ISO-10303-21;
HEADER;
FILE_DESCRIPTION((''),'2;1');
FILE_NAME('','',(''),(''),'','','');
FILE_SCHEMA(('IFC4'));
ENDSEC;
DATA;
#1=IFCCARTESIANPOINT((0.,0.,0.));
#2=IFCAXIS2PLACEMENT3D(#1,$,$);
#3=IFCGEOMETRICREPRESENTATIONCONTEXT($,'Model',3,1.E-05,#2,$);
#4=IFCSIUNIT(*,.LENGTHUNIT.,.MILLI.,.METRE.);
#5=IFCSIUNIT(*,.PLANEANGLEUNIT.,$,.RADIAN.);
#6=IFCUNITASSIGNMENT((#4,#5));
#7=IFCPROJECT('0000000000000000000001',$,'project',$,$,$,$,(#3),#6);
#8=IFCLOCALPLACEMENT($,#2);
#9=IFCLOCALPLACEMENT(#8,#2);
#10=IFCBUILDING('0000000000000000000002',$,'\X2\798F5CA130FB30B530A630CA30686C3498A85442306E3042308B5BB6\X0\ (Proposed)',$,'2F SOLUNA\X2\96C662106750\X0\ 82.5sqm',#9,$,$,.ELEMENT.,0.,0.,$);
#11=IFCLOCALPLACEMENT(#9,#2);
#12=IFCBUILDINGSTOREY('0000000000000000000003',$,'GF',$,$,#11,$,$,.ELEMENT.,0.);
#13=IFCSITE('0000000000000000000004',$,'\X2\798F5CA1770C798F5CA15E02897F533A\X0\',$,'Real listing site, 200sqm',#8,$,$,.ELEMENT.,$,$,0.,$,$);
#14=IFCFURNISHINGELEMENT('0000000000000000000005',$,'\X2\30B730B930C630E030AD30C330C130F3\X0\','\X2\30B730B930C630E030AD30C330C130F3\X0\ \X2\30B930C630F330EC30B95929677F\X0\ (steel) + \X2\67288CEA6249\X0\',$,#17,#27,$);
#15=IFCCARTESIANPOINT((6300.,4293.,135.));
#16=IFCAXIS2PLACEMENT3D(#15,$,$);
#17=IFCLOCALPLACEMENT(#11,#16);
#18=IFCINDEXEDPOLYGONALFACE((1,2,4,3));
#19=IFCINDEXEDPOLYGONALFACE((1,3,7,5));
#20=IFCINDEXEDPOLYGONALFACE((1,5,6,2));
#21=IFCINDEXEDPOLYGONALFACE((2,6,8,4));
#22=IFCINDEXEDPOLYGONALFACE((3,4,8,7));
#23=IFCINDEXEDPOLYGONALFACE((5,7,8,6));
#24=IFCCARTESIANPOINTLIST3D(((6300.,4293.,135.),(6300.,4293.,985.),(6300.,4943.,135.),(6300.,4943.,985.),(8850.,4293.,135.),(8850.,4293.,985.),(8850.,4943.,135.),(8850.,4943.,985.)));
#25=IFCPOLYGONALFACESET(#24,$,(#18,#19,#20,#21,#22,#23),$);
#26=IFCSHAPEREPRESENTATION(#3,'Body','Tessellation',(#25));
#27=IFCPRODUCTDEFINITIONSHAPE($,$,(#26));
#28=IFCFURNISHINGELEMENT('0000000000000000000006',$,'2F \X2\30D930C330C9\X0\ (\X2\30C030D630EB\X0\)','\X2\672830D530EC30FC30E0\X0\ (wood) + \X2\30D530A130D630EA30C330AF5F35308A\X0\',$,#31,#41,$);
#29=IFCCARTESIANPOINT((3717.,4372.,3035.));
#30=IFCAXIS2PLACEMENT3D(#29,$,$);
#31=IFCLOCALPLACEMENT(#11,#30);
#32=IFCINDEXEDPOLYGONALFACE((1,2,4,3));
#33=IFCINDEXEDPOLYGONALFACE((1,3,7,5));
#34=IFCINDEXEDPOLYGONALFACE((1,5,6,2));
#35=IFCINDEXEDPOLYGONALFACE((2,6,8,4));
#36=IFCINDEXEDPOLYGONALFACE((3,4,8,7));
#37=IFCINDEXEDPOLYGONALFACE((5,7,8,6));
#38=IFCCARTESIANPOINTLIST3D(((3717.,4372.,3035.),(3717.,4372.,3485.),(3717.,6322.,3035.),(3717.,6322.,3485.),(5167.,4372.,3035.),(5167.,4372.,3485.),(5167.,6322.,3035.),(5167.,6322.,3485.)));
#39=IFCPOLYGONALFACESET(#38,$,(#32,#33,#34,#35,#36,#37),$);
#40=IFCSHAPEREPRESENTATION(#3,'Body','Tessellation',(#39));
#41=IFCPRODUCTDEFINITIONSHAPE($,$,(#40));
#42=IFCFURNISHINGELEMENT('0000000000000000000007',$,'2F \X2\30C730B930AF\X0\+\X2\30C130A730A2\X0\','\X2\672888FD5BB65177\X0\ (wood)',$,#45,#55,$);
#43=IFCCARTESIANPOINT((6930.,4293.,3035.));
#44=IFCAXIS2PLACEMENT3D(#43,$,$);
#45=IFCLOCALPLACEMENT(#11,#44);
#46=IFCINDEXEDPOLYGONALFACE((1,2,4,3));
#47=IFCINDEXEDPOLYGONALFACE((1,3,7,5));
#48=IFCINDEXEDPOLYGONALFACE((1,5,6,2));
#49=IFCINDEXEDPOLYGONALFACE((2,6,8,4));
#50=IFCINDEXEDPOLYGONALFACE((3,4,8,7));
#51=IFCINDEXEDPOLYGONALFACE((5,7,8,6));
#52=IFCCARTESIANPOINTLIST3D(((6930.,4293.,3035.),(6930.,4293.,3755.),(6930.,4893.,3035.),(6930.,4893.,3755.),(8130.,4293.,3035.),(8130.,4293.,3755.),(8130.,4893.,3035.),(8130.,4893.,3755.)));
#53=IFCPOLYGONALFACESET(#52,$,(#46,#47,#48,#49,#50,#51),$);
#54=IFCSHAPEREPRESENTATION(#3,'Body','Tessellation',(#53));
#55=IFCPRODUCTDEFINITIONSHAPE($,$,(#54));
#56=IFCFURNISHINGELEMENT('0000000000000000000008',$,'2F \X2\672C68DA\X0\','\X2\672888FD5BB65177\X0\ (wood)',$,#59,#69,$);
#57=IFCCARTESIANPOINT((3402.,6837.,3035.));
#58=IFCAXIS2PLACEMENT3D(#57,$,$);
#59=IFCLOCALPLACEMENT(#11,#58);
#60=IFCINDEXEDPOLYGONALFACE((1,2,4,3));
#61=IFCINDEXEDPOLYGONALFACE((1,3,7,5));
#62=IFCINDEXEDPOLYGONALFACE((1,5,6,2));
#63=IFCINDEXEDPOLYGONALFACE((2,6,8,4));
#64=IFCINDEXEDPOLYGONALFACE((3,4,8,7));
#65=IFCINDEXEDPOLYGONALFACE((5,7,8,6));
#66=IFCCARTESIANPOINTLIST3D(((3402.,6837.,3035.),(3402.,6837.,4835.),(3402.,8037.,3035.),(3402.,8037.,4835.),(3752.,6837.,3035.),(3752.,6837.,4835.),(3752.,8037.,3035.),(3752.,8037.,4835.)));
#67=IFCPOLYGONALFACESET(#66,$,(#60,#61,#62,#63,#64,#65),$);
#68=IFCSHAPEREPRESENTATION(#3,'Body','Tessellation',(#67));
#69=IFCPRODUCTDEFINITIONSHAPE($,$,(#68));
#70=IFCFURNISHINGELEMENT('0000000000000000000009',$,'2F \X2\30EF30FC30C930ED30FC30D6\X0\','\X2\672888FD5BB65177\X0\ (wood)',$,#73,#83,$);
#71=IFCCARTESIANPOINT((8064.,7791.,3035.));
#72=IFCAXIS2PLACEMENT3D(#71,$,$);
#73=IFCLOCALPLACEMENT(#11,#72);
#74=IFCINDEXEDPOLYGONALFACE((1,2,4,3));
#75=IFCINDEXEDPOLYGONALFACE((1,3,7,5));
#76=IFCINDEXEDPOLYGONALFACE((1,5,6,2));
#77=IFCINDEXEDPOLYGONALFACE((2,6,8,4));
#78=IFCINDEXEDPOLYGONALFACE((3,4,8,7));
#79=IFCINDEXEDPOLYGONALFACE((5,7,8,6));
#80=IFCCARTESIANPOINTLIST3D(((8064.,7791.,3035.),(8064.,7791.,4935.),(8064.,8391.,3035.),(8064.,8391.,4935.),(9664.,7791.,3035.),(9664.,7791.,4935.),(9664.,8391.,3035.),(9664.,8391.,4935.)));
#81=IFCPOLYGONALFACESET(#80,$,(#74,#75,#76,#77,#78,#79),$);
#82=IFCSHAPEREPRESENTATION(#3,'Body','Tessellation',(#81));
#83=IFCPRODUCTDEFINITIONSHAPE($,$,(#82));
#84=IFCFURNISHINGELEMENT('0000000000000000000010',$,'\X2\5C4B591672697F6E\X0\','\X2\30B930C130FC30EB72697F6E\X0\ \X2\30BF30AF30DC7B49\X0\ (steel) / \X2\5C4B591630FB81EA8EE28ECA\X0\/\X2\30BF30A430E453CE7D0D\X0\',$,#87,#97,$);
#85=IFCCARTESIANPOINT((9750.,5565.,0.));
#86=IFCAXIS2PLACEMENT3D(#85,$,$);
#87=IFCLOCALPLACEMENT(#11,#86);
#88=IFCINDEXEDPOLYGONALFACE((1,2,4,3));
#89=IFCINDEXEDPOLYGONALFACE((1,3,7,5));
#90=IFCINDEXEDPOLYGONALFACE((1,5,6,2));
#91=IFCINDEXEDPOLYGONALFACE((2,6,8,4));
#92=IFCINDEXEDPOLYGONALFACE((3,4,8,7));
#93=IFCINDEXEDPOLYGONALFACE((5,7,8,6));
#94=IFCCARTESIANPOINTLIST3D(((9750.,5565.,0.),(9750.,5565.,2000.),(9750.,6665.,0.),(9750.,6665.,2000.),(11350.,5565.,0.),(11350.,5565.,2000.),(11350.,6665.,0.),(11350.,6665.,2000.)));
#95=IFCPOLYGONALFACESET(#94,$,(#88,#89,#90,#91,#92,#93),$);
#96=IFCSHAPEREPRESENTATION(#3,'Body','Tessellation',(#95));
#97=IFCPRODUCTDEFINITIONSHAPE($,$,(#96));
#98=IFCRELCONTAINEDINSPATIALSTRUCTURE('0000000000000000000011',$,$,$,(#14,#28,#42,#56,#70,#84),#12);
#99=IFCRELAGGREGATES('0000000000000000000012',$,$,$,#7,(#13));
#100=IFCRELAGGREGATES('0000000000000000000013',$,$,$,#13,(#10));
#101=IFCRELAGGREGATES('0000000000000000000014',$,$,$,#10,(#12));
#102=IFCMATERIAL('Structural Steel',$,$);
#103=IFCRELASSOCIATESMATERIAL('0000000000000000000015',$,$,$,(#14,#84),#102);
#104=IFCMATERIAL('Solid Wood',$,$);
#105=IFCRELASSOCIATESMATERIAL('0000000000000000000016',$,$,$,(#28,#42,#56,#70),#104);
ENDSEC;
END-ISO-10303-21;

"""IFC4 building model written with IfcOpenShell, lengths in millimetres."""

from ifc_helpers import new_model, si_unit, frame, frame_2d, origin, place, context, project, spatial, rectangle, extrude, material, element, save


model = new_model("IFC4")

# Units and contexts
model_context = context("Model", 3, precision=1e-05, world=origin())
ifc_project = project(units=[si_unit("LENGTHUNIT", "METRE", prefix="MILLI"), si_unit("PLANEANGLEUNIT", "RADIAN")], contexts=[model_context])

# Site, building, storey
site_placement = place(None, origin())
site = spatial("IfcSite", under=ifc_project, at=site_placement, Name="福岡県福岡市西区", ObjectType="Real listing site, 200sqm", CompositionType="ELEMENT", RefElevation=0.0)
building_placement = place(site_placement, origin())
building = spatial("IfcBuilding", under=site, at=building_placement, Name="福岡・サウナと水風呂のある家 (Proposed)", ObjectType="2F SOLUNA集成材 82.5sqm", CompositionType="ELEMENT", ElevationOfRefHeight=0.0, ElevationOfTerrain=0.0)
storey_placement = place(building_placement, origin())
storey = spatial("IfcBuildingStorey", under=building, at=storey_placement, Name="GF", CompositionType="ELEMENT", Elevation=0.0)

# Shared definitions
ifc_material_1 = material(Name="Solid Wood")

# Shared definitions
ifc_material_2 = material(Name="Structural Steel")

# Furnishing elements
furnishing_1_placement = place(storey_placement, frame((6300.0, 4293.0, 135.0)))
element("IfcFurnishingElement", 1, at=furnishing_1_placement, inside=storey, material=ifc_material_2, Name="システムキッチン", Description="システムキッチン ステンレス天板 (steel) + 木質扉", context=model_context, shape_type="SweptSolid", body=[
    extrude(rectangle(XDim=2550.0, YDim=650.0, at=frame_2d((1275.0, 325.0))), frame((6300.0, 4293.0, 135.0)), (0.0, 0.0, 1.0), 850.0),
])
furnishing_2_placement = place(storey_placement, frame((3717.0, 4372.0, 3035.0)))
element("IfcFurnishingElement", 2, at=furnishing_2_placement, inside=storey, material=ifc_material_1, Name="2F ベッド (ダブル)", Description="木フレーム (wood) + ファブリック張り", context=model_context, shape_type="SweptSolid", body=[
    extrude(rectangle(XDim=1450.0, YDim=1950.0, at=frame_2d((725.0, 975.0))), frame((3717.0, 4372.0, 3035.0)), (0.0, 0.0, 1.0), 450.0),
])
furnishing_3_placement = place(storey_placement, frame((6930.0, 4293.0, 3035.0)))
element("IfcFurnishingElement", 3, at=furnishing_3_placement, inside=storey, material=ifc_material_1, Name="2F デスク+チェア", Description="木製家具 (wood)", context=model_context, shape_type="SweptSolid", body=[
    extrude(rectangle(XDim=1200.0, YDim=600.0, at=frame_2d((600.0, 300.0))), frame((6930.0, 4293.0, 3035.0)), (0.0, 0.0, 1.0), 720.0),
])
furnishing_4_placement = place(storey_placement, frame((3402.0, 6837.0, 3035.0)))
element("IfcFurnishingElement", 4, at=furnishing_4_placement, inside=storey, material=ifc_material_1, Name="2F 本棚", Description="木製家具 (wood)", context=model_context, shape_type="SweptSolid", body=[
    extrude(rectangle(XDim=350.0, YDim=1200.0, at=frame_2d((175.0, 600.0))), frame((3402.0, 6837.0, 3035.0)), (0.0, 0.0, 1.0), 1800.0),
])
furnishing_5_placement = place(storey_placement, frame((8064.0, 7791.0, 3035.0)))
element("IfcFurnishingElement", 5, at=furnishing_5_placement, inside=storey, material=ifc_material_1, Name="2F ワードローブ", Description="木製家具 (wood)", context=model_context, shape_type="SweptSolid", body=[
    extrude(rectangle(XDim=1600.0, YDim=600.0, at=frame_2d((800.0, 300.0))), frame((8064.0, 7791.0, 3035.0)), (0.0, 0.0, 1.0), 1900.0),
])
furnishing_6_placement = place(storey_placement, frame((9750.0, 5565.0, 0.0)))
element("IfcFurnishingElement", 6, at=furnishing_6_placement, inside=storey, material=ifc_material_2, Name="屋外物置", Description="スチール物置 タクボ等 (steel) / 屋外・自転車/タイヤ収納", context=model_context, shape_type="SweptSolid", body=[
    extrude(rectangle(XDim=1600.0, YDim=1100.0, at=frame_2d((800.0, 550.0))), frame((9750.0, 5565.0, 0.0)), (0.0, 0.0, 1.0), 2000.0),
])

save(model, "model.ifc")
